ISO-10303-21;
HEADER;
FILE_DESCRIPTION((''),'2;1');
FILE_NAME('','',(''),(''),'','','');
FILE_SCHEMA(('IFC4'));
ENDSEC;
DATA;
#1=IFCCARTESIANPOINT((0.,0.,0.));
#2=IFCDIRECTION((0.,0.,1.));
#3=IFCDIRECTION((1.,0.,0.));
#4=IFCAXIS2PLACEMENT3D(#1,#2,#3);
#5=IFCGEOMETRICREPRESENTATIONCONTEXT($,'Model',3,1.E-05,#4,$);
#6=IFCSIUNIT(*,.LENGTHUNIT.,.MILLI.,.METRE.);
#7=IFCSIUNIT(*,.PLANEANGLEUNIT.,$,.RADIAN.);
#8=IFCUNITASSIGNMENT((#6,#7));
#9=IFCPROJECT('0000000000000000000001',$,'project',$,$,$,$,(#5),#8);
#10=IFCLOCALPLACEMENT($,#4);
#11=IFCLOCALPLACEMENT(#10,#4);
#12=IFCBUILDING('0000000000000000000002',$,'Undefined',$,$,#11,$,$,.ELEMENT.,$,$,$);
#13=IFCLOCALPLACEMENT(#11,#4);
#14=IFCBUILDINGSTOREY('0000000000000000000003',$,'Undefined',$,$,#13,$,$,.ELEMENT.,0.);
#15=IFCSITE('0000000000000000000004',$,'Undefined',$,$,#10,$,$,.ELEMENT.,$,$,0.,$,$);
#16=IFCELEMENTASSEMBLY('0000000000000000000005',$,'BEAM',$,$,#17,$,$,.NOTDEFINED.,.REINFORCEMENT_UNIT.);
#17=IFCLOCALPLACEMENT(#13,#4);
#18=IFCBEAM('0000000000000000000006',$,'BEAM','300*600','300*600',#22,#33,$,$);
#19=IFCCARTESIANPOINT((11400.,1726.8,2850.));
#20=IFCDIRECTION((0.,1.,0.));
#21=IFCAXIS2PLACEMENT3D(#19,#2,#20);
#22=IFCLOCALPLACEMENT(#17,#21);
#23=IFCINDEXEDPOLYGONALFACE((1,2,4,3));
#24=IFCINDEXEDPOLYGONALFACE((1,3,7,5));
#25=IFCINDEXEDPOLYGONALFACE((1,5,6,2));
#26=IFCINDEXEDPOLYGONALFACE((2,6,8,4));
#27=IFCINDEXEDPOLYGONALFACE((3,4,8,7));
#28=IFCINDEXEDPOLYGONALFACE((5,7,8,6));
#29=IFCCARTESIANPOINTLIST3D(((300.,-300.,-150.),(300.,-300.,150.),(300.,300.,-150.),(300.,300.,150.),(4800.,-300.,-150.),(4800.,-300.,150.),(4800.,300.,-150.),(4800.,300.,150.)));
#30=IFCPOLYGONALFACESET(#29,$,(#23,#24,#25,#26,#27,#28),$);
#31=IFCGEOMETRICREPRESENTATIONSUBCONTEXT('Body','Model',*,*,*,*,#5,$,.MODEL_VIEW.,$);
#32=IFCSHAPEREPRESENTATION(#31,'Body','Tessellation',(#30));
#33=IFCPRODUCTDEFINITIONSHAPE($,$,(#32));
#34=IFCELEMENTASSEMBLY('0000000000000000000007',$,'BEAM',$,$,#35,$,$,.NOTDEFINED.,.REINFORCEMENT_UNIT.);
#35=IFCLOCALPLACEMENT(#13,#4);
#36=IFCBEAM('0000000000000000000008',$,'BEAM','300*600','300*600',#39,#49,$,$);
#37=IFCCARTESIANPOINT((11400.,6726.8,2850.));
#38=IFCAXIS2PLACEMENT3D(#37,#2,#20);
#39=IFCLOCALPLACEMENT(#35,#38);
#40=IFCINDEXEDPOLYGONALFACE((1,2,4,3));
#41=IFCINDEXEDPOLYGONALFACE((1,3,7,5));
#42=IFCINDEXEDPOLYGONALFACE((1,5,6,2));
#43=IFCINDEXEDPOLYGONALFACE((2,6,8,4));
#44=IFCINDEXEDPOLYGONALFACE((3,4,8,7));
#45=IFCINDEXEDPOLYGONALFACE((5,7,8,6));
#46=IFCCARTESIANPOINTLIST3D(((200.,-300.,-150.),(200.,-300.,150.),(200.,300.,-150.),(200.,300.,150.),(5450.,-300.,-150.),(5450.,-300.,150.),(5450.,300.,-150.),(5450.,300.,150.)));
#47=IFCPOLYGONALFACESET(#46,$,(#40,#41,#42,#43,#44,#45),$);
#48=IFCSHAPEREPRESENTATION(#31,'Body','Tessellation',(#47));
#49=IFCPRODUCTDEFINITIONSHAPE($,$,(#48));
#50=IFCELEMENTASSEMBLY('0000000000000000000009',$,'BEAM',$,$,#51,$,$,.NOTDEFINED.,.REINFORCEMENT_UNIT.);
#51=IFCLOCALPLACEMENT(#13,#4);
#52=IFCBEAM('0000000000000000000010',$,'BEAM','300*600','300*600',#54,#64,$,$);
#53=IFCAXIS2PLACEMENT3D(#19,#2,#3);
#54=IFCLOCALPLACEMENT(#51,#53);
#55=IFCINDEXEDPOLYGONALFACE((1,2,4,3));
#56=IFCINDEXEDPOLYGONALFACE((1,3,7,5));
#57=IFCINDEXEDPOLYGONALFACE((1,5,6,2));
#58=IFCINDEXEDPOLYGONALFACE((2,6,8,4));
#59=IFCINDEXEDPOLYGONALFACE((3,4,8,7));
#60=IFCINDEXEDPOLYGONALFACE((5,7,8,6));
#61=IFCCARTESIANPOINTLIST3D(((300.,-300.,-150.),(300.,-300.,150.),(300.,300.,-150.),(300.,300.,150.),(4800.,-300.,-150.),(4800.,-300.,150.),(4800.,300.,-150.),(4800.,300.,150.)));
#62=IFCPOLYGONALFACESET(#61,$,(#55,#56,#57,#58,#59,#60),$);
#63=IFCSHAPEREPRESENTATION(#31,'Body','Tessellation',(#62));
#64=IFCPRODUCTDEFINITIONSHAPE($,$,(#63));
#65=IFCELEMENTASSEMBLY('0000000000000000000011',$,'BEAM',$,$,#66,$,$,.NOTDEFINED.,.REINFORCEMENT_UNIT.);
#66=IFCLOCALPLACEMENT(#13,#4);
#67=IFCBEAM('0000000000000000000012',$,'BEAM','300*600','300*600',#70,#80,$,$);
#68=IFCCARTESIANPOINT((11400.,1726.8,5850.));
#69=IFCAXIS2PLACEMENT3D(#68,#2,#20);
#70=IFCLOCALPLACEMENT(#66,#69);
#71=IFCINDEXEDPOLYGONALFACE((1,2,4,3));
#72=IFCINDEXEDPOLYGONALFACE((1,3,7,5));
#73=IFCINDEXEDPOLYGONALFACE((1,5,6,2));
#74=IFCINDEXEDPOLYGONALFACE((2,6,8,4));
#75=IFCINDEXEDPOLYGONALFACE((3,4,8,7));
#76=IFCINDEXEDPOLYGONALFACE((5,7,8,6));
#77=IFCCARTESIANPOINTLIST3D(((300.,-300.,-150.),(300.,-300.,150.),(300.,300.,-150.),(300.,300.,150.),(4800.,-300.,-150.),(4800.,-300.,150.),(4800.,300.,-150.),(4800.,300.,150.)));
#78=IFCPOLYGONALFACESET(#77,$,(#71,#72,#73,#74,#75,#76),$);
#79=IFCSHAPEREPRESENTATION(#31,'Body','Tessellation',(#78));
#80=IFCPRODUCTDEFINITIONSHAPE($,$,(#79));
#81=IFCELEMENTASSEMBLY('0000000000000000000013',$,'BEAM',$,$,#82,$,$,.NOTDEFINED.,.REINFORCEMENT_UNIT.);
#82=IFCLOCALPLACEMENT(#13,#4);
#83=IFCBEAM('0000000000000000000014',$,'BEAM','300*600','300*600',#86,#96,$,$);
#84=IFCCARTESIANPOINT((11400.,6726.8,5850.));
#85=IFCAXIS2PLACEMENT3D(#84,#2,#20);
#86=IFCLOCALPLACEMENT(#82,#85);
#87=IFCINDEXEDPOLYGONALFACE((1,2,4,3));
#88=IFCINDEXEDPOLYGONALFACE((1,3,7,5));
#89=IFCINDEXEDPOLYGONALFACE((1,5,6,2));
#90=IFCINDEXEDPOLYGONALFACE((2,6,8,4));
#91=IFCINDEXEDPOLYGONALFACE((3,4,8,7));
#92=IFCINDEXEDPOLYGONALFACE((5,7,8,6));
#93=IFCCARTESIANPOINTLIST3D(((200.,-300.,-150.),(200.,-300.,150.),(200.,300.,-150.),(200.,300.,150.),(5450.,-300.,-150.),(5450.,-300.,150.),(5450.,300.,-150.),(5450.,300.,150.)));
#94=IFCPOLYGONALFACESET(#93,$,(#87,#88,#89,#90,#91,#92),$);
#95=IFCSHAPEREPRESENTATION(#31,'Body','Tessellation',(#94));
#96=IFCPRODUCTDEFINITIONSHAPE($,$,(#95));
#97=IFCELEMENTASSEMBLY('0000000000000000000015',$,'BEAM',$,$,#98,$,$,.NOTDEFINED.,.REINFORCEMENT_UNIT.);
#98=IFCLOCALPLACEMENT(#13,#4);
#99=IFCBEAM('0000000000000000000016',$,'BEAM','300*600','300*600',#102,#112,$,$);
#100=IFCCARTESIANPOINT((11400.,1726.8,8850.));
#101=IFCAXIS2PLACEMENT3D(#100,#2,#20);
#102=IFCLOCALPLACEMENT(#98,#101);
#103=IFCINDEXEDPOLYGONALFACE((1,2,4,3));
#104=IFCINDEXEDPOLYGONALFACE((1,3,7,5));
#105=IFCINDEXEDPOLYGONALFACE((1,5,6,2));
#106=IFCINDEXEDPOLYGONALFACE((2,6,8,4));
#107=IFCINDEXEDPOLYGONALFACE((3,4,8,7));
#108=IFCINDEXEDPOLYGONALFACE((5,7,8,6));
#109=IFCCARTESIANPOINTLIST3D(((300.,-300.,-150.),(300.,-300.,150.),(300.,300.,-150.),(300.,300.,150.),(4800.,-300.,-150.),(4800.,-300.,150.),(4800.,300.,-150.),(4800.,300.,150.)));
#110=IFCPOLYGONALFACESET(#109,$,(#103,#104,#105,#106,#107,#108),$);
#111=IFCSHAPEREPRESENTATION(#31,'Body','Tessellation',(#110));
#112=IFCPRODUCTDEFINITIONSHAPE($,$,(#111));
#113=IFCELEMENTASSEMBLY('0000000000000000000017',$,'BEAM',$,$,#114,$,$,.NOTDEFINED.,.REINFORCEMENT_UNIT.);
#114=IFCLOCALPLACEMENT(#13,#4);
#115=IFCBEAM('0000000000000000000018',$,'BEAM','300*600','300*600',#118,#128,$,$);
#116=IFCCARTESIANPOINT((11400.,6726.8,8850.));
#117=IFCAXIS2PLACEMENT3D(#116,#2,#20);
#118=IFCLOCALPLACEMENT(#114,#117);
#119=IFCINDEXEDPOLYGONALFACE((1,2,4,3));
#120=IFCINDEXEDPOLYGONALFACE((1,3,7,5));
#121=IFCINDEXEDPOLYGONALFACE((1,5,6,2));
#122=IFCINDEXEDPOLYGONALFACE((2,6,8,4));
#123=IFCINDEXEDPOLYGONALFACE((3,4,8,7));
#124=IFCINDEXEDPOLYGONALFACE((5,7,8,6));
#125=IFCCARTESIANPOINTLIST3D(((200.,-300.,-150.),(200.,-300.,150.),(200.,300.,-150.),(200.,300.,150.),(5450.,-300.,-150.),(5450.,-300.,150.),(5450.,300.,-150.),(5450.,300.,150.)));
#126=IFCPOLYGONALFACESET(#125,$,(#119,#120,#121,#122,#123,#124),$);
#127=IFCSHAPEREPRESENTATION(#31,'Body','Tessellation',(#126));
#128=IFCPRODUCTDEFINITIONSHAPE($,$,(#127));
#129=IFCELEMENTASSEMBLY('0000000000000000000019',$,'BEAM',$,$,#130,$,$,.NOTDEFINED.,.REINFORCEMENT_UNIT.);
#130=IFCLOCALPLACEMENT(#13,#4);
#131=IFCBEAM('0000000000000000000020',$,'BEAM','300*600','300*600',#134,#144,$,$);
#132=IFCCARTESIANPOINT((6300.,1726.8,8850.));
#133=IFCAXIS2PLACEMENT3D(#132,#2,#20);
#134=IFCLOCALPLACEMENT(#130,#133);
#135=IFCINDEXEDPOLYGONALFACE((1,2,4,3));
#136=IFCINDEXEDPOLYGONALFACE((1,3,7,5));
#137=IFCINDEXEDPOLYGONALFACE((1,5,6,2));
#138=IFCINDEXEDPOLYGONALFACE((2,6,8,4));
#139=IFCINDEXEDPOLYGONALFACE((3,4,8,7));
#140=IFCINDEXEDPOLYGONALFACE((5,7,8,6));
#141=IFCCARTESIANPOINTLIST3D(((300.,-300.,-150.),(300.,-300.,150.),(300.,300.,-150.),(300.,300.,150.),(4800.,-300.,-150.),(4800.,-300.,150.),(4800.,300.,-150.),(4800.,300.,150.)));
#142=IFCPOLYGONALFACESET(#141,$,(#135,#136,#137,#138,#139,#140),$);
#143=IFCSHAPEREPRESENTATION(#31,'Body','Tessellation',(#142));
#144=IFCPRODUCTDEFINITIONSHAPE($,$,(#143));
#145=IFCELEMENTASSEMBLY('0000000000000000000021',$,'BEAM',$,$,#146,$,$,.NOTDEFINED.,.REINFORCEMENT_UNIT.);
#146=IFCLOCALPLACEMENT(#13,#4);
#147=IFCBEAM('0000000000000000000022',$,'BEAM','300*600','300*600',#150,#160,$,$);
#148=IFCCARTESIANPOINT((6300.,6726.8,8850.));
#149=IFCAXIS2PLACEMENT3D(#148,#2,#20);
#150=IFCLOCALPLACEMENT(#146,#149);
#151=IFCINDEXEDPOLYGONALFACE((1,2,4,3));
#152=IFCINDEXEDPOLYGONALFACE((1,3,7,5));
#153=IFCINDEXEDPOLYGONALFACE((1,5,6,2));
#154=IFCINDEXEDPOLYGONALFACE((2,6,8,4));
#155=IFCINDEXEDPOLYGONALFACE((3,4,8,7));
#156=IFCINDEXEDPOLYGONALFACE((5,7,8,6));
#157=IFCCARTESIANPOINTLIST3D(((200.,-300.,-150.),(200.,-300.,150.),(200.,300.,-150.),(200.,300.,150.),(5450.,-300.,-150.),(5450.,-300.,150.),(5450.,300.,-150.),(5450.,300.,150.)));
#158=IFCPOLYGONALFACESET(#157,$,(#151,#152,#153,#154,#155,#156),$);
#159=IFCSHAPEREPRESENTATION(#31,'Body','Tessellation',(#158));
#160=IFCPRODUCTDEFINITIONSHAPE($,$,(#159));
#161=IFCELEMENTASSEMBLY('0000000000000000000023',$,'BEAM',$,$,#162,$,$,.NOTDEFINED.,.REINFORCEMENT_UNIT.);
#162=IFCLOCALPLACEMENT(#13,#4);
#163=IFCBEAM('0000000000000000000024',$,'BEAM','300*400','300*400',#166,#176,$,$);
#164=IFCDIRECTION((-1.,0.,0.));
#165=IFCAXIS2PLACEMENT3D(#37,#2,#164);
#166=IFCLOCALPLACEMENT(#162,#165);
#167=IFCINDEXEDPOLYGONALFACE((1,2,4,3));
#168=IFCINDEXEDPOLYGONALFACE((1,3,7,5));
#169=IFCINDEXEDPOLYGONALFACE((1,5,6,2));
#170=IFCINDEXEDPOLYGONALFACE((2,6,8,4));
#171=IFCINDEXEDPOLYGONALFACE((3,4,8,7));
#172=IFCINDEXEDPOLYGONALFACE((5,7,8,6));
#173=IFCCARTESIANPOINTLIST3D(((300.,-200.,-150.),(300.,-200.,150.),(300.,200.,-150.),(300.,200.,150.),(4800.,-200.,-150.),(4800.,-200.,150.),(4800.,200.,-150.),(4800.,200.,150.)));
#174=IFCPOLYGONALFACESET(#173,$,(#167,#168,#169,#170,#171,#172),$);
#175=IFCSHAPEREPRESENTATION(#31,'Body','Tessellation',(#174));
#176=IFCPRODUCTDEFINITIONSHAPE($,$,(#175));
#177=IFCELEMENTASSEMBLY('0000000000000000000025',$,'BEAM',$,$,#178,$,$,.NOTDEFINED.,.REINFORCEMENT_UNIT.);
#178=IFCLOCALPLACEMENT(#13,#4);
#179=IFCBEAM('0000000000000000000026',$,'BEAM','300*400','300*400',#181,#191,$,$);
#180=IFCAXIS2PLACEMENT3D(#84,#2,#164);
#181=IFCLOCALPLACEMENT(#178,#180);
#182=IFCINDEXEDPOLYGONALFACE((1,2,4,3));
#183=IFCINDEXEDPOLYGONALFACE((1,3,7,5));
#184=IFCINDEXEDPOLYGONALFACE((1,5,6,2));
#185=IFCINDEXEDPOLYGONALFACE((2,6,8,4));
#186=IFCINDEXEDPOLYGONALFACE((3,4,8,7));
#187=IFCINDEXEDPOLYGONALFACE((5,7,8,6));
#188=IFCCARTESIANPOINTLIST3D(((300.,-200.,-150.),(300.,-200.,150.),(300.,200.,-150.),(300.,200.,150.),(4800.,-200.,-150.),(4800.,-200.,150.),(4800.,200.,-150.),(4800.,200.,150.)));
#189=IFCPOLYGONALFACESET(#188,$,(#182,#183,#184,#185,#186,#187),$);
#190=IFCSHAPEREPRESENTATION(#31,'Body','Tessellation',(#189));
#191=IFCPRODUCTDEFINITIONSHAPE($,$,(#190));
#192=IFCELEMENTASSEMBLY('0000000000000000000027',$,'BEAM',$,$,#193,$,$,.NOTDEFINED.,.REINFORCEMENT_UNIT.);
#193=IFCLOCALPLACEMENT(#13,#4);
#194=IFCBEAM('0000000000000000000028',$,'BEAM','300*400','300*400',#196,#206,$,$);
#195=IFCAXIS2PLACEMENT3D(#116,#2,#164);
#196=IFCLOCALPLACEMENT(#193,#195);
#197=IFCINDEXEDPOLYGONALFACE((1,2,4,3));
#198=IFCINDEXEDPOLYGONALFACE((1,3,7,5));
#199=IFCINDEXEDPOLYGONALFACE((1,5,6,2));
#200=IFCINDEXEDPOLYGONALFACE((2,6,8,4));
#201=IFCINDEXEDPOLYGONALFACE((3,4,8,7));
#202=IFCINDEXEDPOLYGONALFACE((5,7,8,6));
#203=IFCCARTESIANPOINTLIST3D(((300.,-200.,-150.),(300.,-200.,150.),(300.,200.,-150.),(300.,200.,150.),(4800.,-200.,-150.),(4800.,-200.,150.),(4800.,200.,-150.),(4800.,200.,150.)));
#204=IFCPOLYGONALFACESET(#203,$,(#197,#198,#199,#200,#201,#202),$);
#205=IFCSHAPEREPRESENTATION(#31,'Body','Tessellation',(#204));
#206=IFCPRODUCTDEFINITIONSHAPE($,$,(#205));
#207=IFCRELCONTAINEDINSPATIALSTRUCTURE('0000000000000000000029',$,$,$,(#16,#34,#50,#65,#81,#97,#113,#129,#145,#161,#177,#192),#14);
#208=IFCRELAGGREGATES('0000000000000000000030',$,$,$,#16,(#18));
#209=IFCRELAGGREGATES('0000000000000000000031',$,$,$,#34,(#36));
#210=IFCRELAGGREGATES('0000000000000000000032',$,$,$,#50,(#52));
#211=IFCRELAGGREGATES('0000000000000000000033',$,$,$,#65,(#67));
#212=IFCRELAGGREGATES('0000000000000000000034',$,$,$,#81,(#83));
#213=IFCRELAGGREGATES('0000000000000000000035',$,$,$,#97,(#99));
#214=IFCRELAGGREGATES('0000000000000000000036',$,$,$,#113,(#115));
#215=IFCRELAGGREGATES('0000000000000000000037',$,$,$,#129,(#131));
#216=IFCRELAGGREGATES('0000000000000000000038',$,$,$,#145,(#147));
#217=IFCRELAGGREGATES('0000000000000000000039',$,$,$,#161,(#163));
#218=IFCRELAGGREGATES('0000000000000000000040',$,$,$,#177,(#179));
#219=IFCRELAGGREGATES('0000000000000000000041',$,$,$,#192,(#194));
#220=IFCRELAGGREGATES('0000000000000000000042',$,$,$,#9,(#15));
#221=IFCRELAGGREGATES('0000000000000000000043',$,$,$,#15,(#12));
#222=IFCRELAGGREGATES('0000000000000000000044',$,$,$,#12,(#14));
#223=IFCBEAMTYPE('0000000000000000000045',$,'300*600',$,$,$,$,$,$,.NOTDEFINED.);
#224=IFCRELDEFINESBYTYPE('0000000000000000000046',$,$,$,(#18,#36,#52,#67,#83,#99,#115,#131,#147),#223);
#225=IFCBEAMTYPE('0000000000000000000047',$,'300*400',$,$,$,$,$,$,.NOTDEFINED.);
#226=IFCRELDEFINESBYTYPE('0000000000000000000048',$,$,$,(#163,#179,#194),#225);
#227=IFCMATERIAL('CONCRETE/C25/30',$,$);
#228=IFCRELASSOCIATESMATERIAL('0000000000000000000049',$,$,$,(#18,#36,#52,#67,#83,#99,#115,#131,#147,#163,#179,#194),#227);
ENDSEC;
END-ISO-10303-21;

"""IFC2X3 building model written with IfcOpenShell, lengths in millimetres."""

from ifc_helpers import new_model, si_unit, frame, origin_with_axes, origin_2d_with_axis, place, context, subcontext, project, spatial, rectangle, extrude, material, type_object, element, aggregate, save


model = new_model("IFC2X3")

# Units and contexts
model_context = context("Model", 3, precision=1e-05, world=origin_with_axes())
body_context = subcontext(model_context, "Body", "Model", "MODEL_VIEW")
ifc_project = project(units=[si_unit("LENGTHUNIT", "METRE", prefix="MILLI"), si_unit("PLANEANGLEUNIT", "RADIAN")], contexts=[model_context])

# Site, building, storey
site_placement = place(None, origin_with_axes())
site = spatial("IfcSite", under=ifc_project, at=site_placement, Name="Undefined", CompositionType="ELEMENT", RefElevation=0.0)
building_placement = place(site_placement, origin_with_axes())
building = spatial("IfcBuilding", under=site, at=building_placement, Name="Undefined", CompositionType="ELEMENT")
storey_placement = place(building_placement, origin_with_axes())
storey = spatial("IfcBuildingStorey", under=building, at=storey_placement, Name="Undefined", CompositionType="ELEMENT", Elevation=0.0)

# Shared definitions
ifc_material = material(Name="CONCRETE/C25/30")

# Element assemblies, beams
assembly_1_placement = place(storey_placement, origin_with_axes())
assembly_1 = element("IfcElementAssembly", 1, at=assembly_1_placement, inside=storey, Name="BEAM", AssemblyPlace="NOTDEFINED", PredefinedType="REINFORCEMENT_UNIT")
beam_type_1 = type_object("IfcBeamType", Name="300*600", PredefinedType="NOTDEFINED")
beam_1_placement = place(assembly_1_placement, frame((11400.0, 1726.8, 2850.0), z_axis=(0.0, 0.0, 1.0), x_axis=(0.0, 1.0, 0.0)))
beam_1 = element("IfcBeam", 2, at=beam_1_placement, type_object=beam_type_1, material=ifc_material, Name="BEAM", Description="300*600", ObjectType="300*600", context=body_context, shape_type="SweptSolid", body=[
    extrude(rectangle(XDim=600.0, YDim=300.0, at=origin_2d_with_axis()), frame((4800.0, 0.0, 0.0), z_axis=(-1.0, 0.0, 0.0), x_axis=(0.0, -1.0, 0.0)), (0.0, 0.0, 1.0), 4500.0),
])
aggregate(assembly_1, [beam_1])
assembly_2_placement = place(storey_placement, origin_with_axes())
assembly_2 = element("IfcElementAssembly", 3, at=assembly_2_placement, inside=storey, Name="BEAM", AssemblyPlace="NOTDEFINED", PredefinedType="REINFORCEMENT_UNIT")
beam_2_placement = place(assembly_2_placement, frame((11400.0, 6726.8, 2850.0), z_axis=(0.0, 0.0, 1.0), x_axis=(0.0, 1.0, 0.0)))
beam_2 = element("IfcBeam", 4, at=beam_2_placement, type_object=beam_type_1, material=ifc_material, Name="BEAM", Description="300*600", ObjectType="300*600", context=body_context, shape_type="SweptSolid", body=[
    extrude(rectangle(XDim=600.0, YDim=300.0, at=origin_2d_with_axis()), frame((5450.0, 0.0, 0.0), z_axis=(-1.0, 0.0, 0.0), x_axis=(0.0, -1.0, 0.0)), (0.0, 0.0, 1.0), 5250.0),
])
aggregate(assembly_2, [beam_2])
assembly_3_placement = place(storey_placement, origin_with_axes())
assembly_3 = element("IfcElementAssembly", 5, at=assembly_3_placement, inside=storey, Name="BEAM", AssemblyPlace="NOTDEFINED", PredefinedType="REINFORCEMENT_UNIT")
beam_3_placement = place(assembly_3_placement, frame((11400.0, 1726.8, 2850.0), z_axis=(0.0, 0.0, 1.0), x_axis=(1.0, 0.0, 0.0)))
beam_3 = element("IfcBeam", 6, at=beam_3_placement, type_object=beam_type_1, material=ifc_material, Name="BEAM", Description="300*600", ObjectType="300*600", context=body_context, shape_type="SweptSolid", body=[
    extrude(rectangle(XDim=600.0, YDim=300.0, at=origin_2d_with_axis()), frame((4800.0, 0.0, 0.0), z_axis=(-1.0, 0.0, 0.0), x_axis=(0.0, -1.0, 0.0)), (0.0, 0.0, 1.0), 4500.0),
])
aggregate(assembly_3, [beam_3])
assembly_4_placement = place(storey_placement, origin_with_axes())
assembly_4 = element("IfcElementAssembly", 7, at=assembly_4_placement, inside=storey, Name="BEAM", AssemblyPlace="NOTDEFINED", PredefinedType="REINFORCEMENT_UNIT")
beam_4_placement = place(assembly_4_placement, frame((11400.0, 1726.8, 5850.0), z_axis=(0.0, 0.0, 1.0), x_axis=(0.0, 1.0, 0.0)))
beam_4 = element("IfcBeam", 8, at=beam_4_placement, type_object=beam_type_1, material=ifc_material, Name="BEAM", Description="300*600", ObjectType="300*600", context=body_context, shape_type="SweptSolid", body=[
    extrude(rectangle(XDim=600.0, YDim=300.0, at=origin_2d_with_axis()), frame((4800.0, 0.0, 0.0), z_axis=(-1.0, 0.0, 0.0), x_axis=(0.0, -1.0, 0.0)), (0.0, 0.0, 1.0), 4500.0),
])
aggregate(assembly_4, [beam_4])
assembly_5_placement = place(storey_placement, origin_with_axes())
assembly_5 = element("IfcElementAssembly", 9, at=assembly_5_placement, inside=storey, Name="BEAM", AssemblyPlace="NOTDEFINED", PredefinedType="REINFORCEMENT_UNIT")
beam_5_placement = place(assembly_5_placement, frame((11400.0, 6726.8, 5850.0), z_axis=(0.0, 0.0, 1.0), x_axis=(0.0, 1.0, 0.0)))
beam_5 = element("IfcBeam", 10, at=beam_5_placement, type_object=beam_type_1, material=ifc_material, Name="BEAM", Description="300*600", ObjectType="300*600", context=body_context, shape_type="SweptSolid", body=[
    extrude(rectangle(XDim=600.0, YDim=300.0, at=origin_2d_with_axis()), frame((5450.0, 0.0, 0.0), z_axis=(-1.0, 0.0, 0.0), x_axis=(0.0, -1.0, 0.0)), (0.0, 0.0, 1.0), 5250.0),
])
aggregate(assembly_5, [beam_5])
assembly_6_placement = place(storey_placement, origin_with_axes())
assembly_6 = element("IfcElementAssembly", 11, at=assembly_6_placement, inside=storey, Name="BEAM", AssemblyPlace="NOTDEFINED", PredefinedType="REINFORCEMENT_UNIT")
beam_6_placement = place(assembly_6_placement, frame((11400.0, 1726.8, 8850.0), z_axis=(0.0, 0.0, 1.0), x_axis=(0.0, 1.0, 0.0)))
beam_6 = element("IfcBeam", 12, at=beam_6_placement, type_object=beam_type_1, material=ifc_material, Name="BEAM", Description="300*600", ObjectType="300*600", context=body_context, shape_type="SweptSolid", body=[
    extrude(rectangle(XDim=600.0, YDim=300.0, at=origin_2d_with_axis()), frame((4800.0, 0.0, 0.0), z_axis=(-1.0, 0.0, 0.0), x_axis=(0.0, -1.0, 0.0)), (0.0, 0.0, 1.0), 4500.0),
])
aggregate(assembly_6, [beam_6])
assembly_7_placement = place(storey_placement, origin_with_axes())
assembly_7 = element("IfcElementAssembly", 13, at=assembly_7_placement, inside=storey, Name="BEAM", AssemblyPlace="NOTDEFINED", PredefinedType="REINFORCEMENT_UNIT")
beam_7_placement = place(assembly_7_placement, frame((11400.0, 6726.8, 8850.0), z_axis=(0.0, 0.0, 1.0), x_axis=(0.0, 1.0, 0.0)))
beam_7 = element("IfcBeam", 14, at=beam_7_placement, type_object=beam_type_1, material=ifc_material, Name="BEAM", Description="300*600", ObjectType="300*600", context=body_context, shape_type="SweptSolid", body=[
    extrude(rectangle(XDim=600.0, YDim=300.0, at=origin_2d_with_axis()), frame((5450.0, 0.0, 0.0), z_axis=(-1.0, 0.0, 0.0), x_axis=(0.0, -1.0, 0.0)), (0.0, 0.0, 1.0), 5250.0),
])
aggregate(assembly_7, [beam_7])
assembly_8_placement = place(storey_placement, origin_with_axes())
assembly_8 = element("IfcElementAssembly", 15, at=assembly_8_placement, inside=storey, Name="BEAM", AssemblyPlace="NOTDEFINED", PredefinedType="REINFORCEMENT_UNIT")
beam_8_placement = place(assembly_8_placement, frame((6300.0, 1726.8, 8850.0), z_axis=(0.0, 0.0, 1.0), x_axis=(0.0, 1.0, 0.0)))
beam_8 = element("IfcBeam", 16, at=beam_8_placement, type_object=beam_type_1, material=ifc_material, Name="BEAM", Description="300*600", ObjectType="300*600", context=body_context, shape_type="SweptSolid", body=[
    extrude(rectangle(XDim=600.0, YDim=300.0, at=origin_2d_with_axis()), frame((4800.0, 0.0, 0.0), z_axis=(-1.0, 0.0, 0.0), x_axis=(0.0, -1.0, 0.0)), (0.0, 0.0, 1.0), 4500.0),
])
aggregate(assembly_8, [beam_8])
assembly_9_placement = place(storey_placement, origin_with_axes())
assembly_9 = element("IfcElementAssembly", 17, at=assembly_9_placement, inside=storey, Name="BEAM", AssemblyPlace="NOTDEFINED", PredefinedType="REINFORCEMENT_UNIT")
beam_9_placement = place(assembly_9_placement, frame((6300.0, 6726.8, 8850.0), z_axis=(0.0, 0.0, 1.0), x_axis=(0.0, 1.0, 0.0)))
beam_9 = element("IfcBeam", 18, at=beam_9_placement, type_object=beam_type_1, material=ifc_material, Name="BEAM", Description="300*600", ObjectType="300*600", context=body_context, shape_type="SweptSolid", body=[
    extrude(rectangle(XDim=600.0, YDim=300.0, at=origin_2d_with_axis()), frame((5450.0, 0.0, 0.0), z_axis=(-1.0, 0.0, 0.0), x_axis=(0.0, -1.0, 0.0)), (0.0, 0.0, 1.0), 5250.0),
])
aggregate(assembly_9, [beam_9])
assembly_10_placement = place(storey_placement, origin_with_axes())
assembly_10 = element("IfcElementAssembly", 19, at=assembly_10_placement, inside=storey, Name="BEAM", AssemblyPlace="NOTDEFINED", PredefinedType="REINFORCEMENT_UNIT")
beam_type_2 = type_object("IfcBeamType", Name="300*400", PredefinedType="NOTDEFINED")
beam_10_placement = place(assembly_10_placement, frame((11400.0, 6726.8, 2850.0), z_axis=(0.0, 0.0, 1.0), x_axis=(-1.0, 0.0, 0.0)))
beam_10 = element("IfcBeam", 20, at=beam_10_placement, type_object=beam_type_2, material=ifc_material, Name="BEAM", Description="300*400", ObjectType="300*400", context=body_context, shape_type="SweptSolid", body=[
    extrude(rectangle(XDim=400.0, YDim=300.0, at=origin_2d_with_axis()), frame((4800.0, 0.0, 0.0), z_axis=(-1.0, 0.0, 0.0), x_axis=(0.0, -1.0, 0.0)), (0.0, 0.0, 1.0), 4500.0),
])
aggregate(assembly_10, [beam_10])
assembly_11_placement = place(storey_placement, origin_with_axes())
assembly_11 = element("IfcElementAssembly", 21, at=assembly_11_placement, inside=storey, Name="BEAM", AssemblyPlace="NOTDEFINED", PredefinedType="REINFORCEMENT_UNIT")
beam_11_placement = place(assembly_11_placement, frame((11400.0, 6726.8, 5850.0), z_axis=(0.0, 0.0, 1.0), x_axis=(-1.0, 0.0, 0.0)))
beam_11 = element("IfcBeam", 22, at=beam_11_placement, type_object=beam_type_2, material=ifc_material, Name="BEAM", Description="300*400", ObjectType="300*400", context=body_context, shape_type="SweptSolid", body=[
    extrude(rectangle(XDim=400.0, YDim=300.0, at=origin_2d_with_axis()), frame((4800.0, 0.0, 0.0), z_axis=(-1.0, 0.0, 0.0), x_axis=(0.0, -1.0, 0.0)), (0.0, 0.0, 1.0), 4500.0),
])
aggregate(assembly_11, [beam_11])
assembly_12_placement = place(storey_placement, origin_with_axes())
assembly_12 = element("IfcElementAssembly", 23, at=assembly_12_placement, inside=storey, Name="BEAM", AssemblyPlace="NOTDEFINED", PredefinedType="REINFORCEMENT_UNIT")
beam_12_placement = place(assembly_12_placement, frame((11400.0, 6726.8, 8850.0), z_axis=(0.0, 0.0, 1.0), x_axis=(-1.0, 0.0, 0.0)))
beam_12 = element("IfcBeam", 24, at=beam_12_placement, type_object=beam_type_2, material=ifc_material, Name="BEAM", Description="300*400", ObjectType="300*400", context=body_context, shape_type="SweptSolid", body=[
    extrude(rectangle(XDim=400.0, YDim=300.0, at=origin_2d_with_axis()), frame((4800.0, 0.0, 0.0), z_axis=(-1.0, 0.0, 0.0), x_axis=(0.0, -1.0, 0.0)), (0.0, 0.0, 1.0), 4500.0),
])
aggregate(assembly_12, [beam_12])

save(model, "model.ifc")
